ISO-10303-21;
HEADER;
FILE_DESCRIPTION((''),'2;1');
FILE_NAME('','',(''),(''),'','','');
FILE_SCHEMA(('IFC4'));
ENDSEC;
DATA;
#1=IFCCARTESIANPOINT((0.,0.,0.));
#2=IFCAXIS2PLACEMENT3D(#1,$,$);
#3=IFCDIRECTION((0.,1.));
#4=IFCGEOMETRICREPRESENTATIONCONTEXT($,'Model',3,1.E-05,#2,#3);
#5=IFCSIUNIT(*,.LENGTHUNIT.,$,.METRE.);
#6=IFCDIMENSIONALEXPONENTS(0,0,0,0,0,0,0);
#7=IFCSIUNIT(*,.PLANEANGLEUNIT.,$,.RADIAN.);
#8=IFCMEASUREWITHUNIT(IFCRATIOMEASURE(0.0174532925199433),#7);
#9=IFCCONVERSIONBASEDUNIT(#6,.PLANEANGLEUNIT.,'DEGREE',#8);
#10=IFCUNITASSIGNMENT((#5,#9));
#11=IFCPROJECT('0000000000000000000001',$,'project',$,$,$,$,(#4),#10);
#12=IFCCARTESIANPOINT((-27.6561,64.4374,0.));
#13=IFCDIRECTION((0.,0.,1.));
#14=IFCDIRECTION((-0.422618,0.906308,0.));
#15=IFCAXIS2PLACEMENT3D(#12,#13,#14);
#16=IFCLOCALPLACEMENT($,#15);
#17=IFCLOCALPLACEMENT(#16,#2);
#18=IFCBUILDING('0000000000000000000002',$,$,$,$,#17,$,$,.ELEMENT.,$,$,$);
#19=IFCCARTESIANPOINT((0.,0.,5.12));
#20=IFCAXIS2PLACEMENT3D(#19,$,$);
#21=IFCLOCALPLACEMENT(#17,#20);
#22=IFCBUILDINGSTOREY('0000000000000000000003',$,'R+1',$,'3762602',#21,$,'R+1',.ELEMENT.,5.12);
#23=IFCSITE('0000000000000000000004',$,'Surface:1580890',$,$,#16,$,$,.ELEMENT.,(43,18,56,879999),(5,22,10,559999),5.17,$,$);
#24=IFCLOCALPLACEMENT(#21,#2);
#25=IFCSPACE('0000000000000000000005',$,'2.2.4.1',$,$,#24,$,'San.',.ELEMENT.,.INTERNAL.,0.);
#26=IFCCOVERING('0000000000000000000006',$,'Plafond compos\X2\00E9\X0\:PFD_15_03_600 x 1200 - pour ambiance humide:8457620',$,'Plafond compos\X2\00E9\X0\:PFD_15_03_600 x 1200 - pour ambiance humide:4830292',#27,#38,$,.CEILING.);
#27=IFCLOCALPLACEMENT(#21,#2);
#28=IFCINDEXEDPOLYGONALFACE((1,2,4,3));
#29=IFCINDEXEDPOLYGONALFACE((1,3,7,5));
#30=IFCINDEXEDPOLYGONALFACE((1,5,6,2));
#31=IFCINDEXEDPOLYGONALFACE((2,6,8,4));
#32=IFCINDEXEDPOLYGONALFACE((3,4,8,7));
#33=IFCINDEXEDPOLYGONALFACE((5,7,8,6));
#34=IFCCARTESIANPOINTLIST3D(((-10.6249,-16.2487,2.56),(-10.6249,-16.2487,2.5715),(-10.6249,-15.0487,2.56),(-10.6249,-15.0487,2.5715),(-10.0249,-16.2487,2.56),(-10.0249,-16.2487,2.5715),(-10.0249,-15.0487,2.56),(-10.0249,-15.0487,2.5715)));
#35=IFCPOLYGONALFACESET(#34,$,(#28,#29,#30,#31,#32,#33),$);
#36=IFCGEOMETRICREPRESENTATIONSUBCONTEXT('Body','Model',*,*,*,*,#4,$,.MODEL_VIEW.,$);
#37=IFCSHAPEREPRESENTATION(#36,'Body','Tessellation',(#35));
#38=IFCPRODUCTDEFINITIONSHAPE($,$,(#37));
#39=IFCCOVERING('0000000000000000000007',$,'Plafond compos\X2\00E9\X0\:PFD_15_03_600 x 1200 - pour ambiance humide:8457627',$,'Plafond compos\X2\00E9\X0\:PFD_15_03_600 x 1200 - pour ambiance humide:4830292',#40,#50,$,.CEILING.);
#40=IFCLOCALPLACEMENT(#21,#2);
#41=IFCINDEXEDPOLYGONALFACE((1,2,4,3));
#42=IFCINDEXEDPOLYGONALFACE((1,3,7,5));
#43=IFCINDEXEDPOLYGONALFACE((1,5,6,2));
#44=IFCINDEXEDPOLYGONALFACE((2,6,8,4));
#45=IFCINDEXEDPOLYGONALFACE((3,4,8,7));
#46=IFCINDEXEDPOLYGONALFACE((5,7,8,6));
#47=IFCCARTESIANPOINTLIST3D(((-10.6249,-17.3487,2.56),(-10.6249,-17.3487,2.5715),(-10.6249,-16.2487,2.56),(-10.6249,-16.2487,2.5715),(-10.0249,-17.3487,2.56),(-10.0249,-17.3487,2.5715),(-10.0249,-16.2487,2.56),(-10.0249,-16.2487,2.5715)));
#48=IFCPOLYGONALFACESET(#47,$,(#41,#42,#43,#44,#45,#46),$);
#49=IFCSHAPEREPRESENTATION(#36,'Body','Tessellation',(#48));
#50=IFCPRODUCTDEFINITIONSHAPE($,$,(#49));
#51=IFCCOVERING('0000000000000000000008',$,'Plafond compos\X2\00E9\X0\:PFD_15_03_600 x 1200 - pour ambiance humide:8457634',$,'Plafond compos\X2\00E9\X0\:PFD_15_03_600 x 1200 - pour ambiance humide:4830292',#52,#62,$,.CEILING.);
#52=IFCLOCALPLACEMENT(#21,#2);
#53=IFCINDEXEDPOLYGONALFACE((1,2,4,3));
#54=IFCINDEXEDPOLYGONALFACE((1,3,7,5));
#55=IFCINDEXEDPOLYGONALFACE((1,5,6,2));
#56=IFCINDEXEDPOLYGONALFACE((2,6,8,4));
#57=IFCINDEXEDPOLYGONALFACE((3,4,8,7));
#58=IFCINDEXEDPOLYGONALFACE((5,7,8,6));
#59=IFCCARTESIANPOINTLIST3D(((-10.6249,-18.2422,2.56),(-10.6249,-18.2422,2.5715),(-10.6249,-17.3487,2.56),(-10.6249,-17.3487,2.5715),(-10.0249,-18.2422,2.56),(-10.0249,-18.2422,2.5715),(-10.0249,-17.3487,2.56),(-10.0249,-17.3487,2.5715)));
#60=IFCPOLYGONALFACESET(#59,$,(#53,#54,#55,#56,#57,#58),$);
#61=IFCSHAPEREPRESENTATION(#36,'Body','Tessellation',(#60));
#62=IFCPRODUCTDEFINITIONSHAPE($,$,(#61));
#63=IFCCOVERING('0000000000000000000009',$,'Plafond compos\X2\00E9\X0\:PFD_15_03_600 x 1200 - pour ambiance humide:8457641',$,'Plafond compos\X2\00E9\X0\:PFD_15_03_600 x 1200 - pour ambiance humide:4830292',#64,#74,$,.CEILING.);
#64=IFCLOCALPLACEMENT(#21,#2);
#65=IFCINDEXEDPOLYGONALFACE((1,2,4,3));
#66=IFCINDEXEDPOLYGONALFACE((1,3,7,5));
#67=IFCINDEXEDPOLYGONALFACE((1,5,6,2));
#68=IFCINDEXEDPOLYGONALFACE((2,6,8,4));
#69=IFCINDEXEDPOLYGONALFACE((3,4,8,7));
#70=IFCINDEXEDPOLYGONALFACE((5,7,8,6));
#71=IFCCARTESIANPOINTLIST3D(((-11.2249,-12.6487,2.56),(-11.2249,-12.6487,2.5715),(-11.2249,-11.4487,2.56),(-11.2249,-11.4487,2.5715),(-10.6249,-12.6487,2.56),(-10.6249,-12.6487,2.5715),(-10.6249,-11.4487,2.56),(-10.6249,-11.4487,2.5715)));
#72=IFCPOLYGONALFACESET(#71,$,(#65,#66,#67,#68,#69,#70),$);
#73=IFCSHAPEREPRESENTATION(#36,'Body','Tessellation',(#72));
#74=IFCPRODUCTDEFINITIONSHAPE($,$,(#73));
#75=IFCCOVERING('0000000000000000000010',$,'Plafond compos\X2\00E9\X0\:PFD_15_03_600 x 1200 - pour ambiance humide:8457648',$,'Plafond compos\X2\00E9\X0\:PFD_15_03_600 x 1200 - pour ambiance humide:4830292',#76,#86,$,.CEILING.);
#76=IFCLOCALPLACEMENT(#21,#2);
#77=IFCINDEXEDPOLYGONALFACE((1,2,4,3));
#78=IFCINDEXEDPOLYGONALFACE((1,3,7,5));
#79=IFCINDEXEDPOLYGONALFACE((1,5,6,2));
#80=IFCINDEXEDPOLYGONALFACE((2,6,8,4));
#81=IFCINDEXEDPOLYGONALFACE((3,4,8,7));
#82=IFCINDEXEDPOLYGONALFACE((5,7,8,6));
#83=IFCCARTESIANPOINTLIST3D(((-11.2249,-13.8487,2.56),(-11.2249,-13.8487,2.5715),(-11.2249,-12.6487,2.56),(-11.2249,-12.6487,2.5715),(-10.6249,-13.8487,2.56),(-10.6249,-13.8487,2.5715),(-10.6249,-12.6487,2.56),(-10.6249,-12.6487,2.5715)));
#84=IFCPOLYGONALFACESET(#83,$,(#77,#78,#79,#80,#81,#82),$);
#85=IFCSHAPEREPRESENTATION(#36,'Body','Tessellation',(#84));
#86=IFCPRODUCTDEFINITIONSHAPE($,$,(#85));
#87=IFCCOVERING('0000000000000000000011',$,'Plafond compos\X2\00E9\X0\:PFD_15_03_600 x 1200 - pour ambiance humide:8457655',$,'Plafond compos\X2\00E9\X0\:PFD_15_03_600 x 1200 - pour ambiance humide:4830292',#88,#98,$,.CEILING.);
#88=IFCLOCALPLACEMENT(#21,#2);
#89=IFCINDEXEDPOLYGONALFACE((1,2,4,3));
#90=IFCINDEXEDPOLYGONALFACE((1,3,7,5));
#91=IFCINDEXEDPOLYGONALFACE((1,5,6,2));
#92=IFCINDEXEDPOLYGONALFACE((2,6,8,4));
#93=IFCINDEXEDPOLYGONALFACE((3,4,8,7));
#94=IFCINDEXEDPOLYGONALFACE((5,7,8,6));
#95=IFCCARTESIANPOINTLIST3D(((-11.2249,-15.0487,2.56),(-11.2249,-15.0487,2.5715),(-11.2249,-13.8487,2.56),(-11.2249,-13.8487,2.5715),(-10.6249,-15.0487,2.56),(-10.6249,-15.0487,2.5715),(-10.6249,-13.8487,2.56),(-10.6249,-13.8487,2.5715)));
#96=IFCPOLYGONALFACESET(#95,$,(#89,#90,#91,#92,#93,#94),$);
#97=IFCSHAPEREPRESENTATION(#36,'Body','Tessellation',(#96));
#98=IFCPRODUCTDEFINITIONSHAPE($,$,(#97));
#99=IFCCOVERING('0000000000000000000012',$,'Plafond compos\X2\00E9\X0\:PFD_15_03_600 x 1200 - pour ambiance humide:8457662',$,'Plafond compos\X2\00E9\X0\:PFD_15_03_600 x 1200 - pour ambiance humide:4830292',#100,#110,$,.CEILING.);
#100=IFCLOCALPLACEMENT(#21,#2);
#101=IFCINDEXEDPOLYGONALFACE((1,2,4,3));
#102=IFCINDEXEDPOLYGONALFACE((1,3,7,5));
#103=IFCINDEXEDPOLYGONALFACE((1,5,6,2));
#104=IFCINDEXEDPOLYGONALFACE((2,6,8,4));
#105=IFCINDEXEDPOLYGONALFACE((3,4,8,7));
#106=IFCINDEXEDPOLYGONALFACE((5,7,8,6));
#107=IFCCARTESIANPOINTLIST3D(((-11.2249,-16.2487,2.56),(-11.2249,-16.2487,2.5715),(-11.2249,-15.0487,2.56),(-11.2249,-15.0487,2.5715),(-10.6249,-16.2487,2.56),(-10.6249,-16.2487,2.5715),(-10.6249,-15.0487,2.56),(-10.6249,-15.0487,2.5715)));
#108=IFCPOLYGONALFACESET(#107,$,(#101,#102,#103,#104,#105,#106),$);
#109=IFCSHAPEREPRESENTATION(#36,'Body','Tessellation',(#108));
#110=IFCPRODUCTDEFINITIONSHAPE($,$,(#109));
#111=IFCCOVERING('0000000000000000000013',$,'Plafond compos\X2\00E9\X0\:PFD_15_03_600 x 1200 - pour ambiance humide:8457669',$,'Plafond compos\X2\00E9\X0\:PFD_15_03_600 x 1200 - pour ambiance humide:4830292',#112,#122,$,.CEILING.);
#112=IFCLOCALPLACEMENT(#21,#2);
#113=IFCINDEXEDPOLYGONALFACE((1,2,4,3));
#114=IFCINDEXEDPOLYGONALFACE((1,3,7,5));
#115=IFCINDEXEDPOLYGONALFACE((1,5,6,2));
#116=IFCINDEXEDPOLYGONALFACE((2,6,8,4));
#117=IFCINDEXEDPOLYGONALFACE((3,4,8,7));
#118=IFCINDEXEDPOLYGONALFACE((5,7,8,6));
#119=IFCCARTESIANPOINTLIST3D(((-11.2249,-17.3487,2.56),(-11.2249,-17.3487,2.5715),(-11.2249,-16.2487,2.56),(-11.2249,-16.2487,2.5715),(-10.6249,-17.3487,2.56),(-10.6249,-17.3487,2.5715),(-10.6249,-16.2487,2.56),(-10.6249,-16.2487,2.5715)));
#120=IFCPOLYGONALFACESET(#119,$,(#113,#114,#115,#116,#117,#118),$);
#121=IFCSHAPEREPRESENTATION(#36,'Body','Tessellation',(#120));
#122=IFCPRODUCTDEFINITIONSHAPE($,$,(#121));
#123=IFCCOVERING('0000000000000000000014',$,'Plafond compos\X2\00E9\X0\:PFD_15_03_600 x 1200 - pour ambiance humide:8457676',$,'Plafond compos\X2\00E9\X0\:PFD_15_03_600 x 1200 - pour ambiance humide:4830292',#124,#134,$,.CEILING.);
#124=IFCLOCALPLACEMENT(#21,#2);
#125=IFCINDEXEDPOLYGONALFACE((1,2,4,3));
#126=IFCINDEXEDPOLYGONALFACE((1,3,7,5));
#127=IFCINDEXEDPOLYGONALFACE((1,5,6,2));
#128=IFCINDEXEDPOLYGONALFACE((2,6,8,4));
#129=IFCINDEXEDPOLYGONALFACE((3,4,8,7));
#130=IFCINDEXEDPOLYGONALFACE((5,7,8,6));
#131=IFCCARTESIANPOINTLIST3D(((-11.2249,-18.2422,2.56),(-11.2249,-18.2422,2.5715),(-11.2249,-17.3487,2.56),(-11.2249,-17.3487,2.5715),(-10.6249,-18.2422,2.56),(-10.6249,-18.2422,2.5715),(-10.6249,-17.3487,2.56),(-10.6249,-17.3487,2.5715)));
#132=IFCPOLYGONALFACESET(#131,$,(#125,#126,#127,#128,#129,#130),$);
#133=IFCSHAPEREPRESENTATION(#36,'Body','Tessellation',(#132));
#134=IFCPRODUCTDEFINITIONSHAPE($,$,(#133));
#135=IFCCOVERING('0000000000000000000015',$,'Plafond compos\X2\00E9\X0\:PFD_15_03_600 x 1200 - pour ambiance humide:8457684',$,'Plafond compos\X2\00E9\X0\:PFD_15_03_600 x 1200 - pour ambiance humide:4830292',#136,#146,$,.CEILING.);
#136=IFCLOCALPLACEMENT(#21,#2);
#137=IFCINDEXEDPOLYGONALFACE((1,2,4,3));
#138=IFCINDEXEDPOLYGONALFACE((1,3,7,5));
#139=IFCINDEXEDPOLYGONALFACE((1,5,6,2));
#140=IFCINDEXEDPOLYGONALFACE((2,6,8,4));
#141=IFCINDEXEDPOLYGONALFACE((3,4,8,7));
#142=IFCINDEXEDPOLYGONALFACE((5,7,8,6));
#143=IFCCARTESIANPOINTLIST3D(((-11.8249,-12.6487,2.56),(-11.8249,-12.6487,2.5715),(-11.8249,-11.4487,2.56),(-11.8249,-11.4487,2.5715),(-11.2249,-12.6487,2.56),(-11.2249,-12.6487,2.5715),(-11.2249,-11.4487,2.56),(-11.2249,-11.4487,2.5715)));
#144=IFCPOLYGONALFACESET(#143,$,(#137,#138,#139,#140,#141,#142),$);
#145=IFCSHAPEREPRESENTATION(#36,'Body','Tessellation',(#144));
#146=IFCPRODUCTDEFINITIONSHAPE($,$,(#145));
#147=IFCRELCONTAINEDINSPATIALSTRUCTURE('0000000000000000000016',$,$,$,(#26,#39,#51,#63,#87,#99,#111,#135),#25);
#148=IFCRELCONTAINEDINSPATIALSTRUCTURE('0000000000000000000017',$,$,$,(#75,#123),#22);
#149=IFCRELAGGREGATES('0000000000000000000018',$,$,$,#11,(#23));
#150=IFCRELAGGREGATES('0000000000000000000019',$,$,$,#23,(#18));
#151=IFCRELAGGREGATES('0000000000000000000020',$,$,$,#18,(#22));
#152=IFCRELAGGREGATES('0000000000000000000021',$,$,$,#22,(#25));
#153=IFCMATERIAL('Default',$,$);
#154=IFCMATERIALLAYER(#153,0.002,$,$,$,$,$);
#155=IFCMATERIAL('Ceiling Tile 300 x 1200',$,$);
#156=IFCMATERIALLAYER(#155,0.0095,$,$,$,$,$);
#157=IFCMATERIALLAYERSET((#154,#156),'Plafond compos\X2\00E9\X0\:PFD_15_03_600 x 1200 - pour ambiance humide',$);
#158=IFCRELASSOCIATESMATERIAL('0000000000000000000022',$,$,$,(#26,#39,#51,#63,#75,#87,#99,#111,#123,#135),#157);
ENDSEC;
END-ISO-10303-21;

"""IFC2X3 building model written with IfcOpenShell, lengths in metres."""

from ifc_helpers import new_model, entity, si_unit, converted_unit, direction, frame, frame_2d, origin, place, context, subcontext, project, spatial, rectangle, extrude, material, layer, layer_set, layer_usage, element, save


model = new_model("IFC2X3")

# Units and contexts
model_context = context("Model", 3, precision=1e-05, world=origin(), true_north=direction((0.0, 1.0)))
body_context = subcontext(model_context, "Body", "Model", "MODEL_VIEW")
ifc_project = project(units=[si_unit("LENGTHUNIT", "METRE"), converted_unit("PLANEANGLEUNIT", "DEGREE", entity("IfcRatioMeasure", 0.0174532925199433), si_unit("PLANEANGLEUNIT", "RADIAN"), dimensions=[0, 0, 0, 0, 0, 0, 0])], contexts=[model_context])

# Site, building, storey
site_placement = place(None, frame((-27.6561, 64.4374, 0.0), z_axis=(0.0, 0.0, 1.0), x_axis=(-0.422618, 0.906308, 0.0)))
site = spatial("IfcSite", under=ifc_project, at=site_placement, Name="Surface:1580890", CompositionType="ELEMENT", RefLatitude=(43, 18, 56, 879999), RefLongitude=(5, 22, 10, 559999), RefElevation=5.17)
building_placement = place(site_placement, origin())
building = spatial("IfcBuilding", under=site, at=building_placement, CompositionType="ELEMENT")
storey_placement = place(building_placement, frame((0.0, 0.0, 5.12)))
storey = spatial("IfcBuildingStorey", under=building, at=storey_placement, Name="R+1", ObjectType="3762602", LongName="R+1", CompositionType="ELEMENT", Elevation=5.12)

# Shared definitions
ifc_material_1 = material(Name="Default")
ifc_layer_1 = layer(ifc_material_1, 0.002)
ifc_material_2 = material(Name="Ceiling Tile 300 x 1200")
ifc_layer_2 = layer(ifc_material_2, 0.0095)
ifc_layer_set = layer_set([ifc_layer_1, ifc_layer_2], Name="Plafond composé:PFD_15_03_600 x 1200 - pour ambiance humide")

# Shared definitions
space_placement = place(storey_placement, origin())
space = spatial("IfcSpace", under=storey, at=space_placement, Name="2.2.4.1", LongName="San.", CompositionType="ELEMENT", InteriorOrExteriorSpace="INTERNAL", ElevationWithFlooring=0.0)

# Coverings
ifc_layer_usage_1 = layer_usage(ifc_layer_set, "AXIS3", "POSITIVE", 0.0)
covering_1_placement = place(space_placement, origin())
element("IfcCovering", 1, at=covering_1_placement, inside=space, material=ifc_layer_usage_1, Name="Plafond composé:PFD_15_03_600 x 1200 - pour ambiance humide:8457620", ObjectType="Plafond composé:PFD_15_03_600 x 1200 - pour ambiance humide:4830292", PredefinedType="CEILING", context=body_context, shape_type="SweptSolid", body=[
    extrude(rectangle(XDim=0.6, YDim=1.2, at=frame_2d((0.0, 0.0), x_axis=(1.0, 0.0))), frame((-10.3249, -15.6487, 2.56), z_axis=(0.0, 0.0, 1.0), x_axis=(-1.0, 0.0, 0.0)), (0.0, 0.0, 1.0), 0.0115),
])
ifc_layer_usage_2 = layer_usage(ifc_layer_set, "AXIS3", "POSITIVE", 0.0)
covering_2_placement = place(space_placement, origin())
element("IfcCovering", 2, at=covering_2_placement, inside=space, material=ifc_layer_usage_2, Name="Plafond composé:PFD_15_03_600 x 1200 - pour ambiance humide:8457627", ObjectType="Plafond composé:PFD_15_03_600 x 1200 - pour ambiance humide:4830292", PredefinedType="CEILING", context=body_context, shape_type="SweptSolid", body=[
    extrude(rectangle(XDim=0.6, YDim=1.1, at=frame_2d((0.0, 0.0), x_axis=(1.0, 0.0))), frame((-10.3249, -16.7987, 2.56), z_axis=(0.0, 0.0, 1.0), x_axis=(-1.0, 0.0, 0.0)), (0.0, 0.0, 1.0), 0.0115),
])
ifc_layer_usage_3 = layer_usage(ifc_layer_set, "AXIS3", "POSITIVE", 0.0)
covering_3_placement = place(space_placement, origin())
element("IfcCovering", 3, at=covering_3_placement, inside=space, material=ifc_layer_usage_3, Name="Plafond composé:PFD_15_03_600 x 1200 - pour ambiance humide:8457634", ObjectType="Plafond composé:PFD_15_03_600 x 1200 - pour ambiance humide:4830292", PredefinedType="CEILING", context=body_context, shape_type="SweptSolid", body=[
    extrude(rectangle(XDim=0.6, YDim=0.8935, at=frame_2d((0.0, 0.0), x_axis=(1.0, 0.0))), frame((-10.3249, -17.7955, 2.56), z_axis=(0.0, 0.0, 1.0), x_axis=(-1.0, 0.0, 0.0)), (0.0, 0.0, 1.0), 0.0115),
])
ifc_layer_usage_4 = layer_usage(ifc_layer_set, "AXIS3", "POSITIVE", 0.0)
covering_4_placement = place(space_placement, origin())
element("IfcCovering", 4, at=covering_4_placement, inside=space, material=ifc_layer_usage_4, Name="Plafond composé:PFD_15_03_600 x 1200 - pour ambiance humide:8457641", ObjectType="Plafond composé:PFD_15_03_600 x 1200 - pour ambiance humide:4830292", PredefinedType="CEILING", context=body_context, shape_type="SweptSolid", body=[
    extrude(rectangle(XDim=0.6, YDim=1.2, at=frame_2d((0.0, 0.0), x_axis=(1.0, 0.0))), frame((-10.9249, -12.0487, 2.56), z_axis=(0.0, 0.0, 1.0), x_axis=(-1.0, 0.0, 0.0)), (0.0, 0.0, 1.0), 0.0115),
])
ifc_layer_usage_5 = layer_usage(ifc_layer_set, "AXIS3", "POSITIVE", 0.0)
covering_5_placement = place(storey_placement, origin())
element("IfcCovering", 5, at=covering_5_placement, inside=storey, material=ifc_layer_usage_5, Name="Plafond composé:PFD_15_03_600 x 1200 - pour ambiance humide:8457648", ObjectType="Plafond composé:PFD_15_03_600 x 1200 - pour ambiance humide:4830292", PredefinedType="CEILING", context=body_context, shape_type="SweptSolid", body=[
    extrude(rectangle(XDim=0.6, YDim=1.2, at=frame_2d((0.0, 0.0), x_axis=(1.0, 0.0))), frame((-10.9249, -13.2487, 2.56), z_axis=(0.0, 0.0, 1.0), x_axis=(-1.0, 0.0, 0.0)), (0.0, 0.0, 1.0), 0.0115),
])
ifc_layer_usage_6 = layer_usage(ifc_layer_set, "AXIS3", "POSITIVE", 0.0)
covering_6_placement = place(space_placement, origin())
element("IfcCovering", 6, at=covering_6_placement, inside=space, material=ifc_layer_usage_6, Name="Plafond composé:PFD_15_03_600 x 1200 - pour ambiance humide:8457655", ObjectType="Plafond composé:PFD_15_03_600 x 1200 - pour ambiance humide:4830292", PredefinedType="CEILING", context=body_context, shape_type="SweptSolid", body=[
    extrude(rectangle(XDim=0.6, YDim=1.2, at=frame_2d((0.0, 0.0), x_axis=(1.0, 0.0))), frame((-10.9249, -14.4487, 2.56), z_axis=(0.0, 0.0, 1.0), x_axis=(-1.0, 0.0, 0.0)), (0.0, 0.0, 1.0), 0.0115),
])
ifc_layer_usage_7 = layer_usage(ifc_layer_set, "AXIS3", "POSITIVE", 0.0)
covering_7_placement = place(space_placement, origin())
element("IfcCovering", 7, at=covering_7_placement, inside=space, material=ifc_layer_usage_7, Name="Plafond composé:PFD_15_03_600 x 1200 - pour ambiance humide:8457662", ObjectType="Plafond composé:PFD_15_03_600 x 1200 - pour ambiance humide:4830292", PredefinedType="CEILING", context=body_context, shape_type="SweptSolid", body=[
    extrude(rectangle(XDim=0.6, YDim=1.2, at=frame_2d((0.0, 0.0), x_axis=(1.0, 0.0))), frame((-10.9249, -15.6487, 2.56), z_axis=(0.0, 0.0, 1.0), x_axis=(-1.0, 0.0, 0.0)), (0.0, 0.0, 1.0), 0.0115),
])
ifc_layer_usage_8 = layer_usage(ifc_layer_set, "AXIS3", "POSITIVE", 0.0)
covering_8_placement = place(space_placement, origin())
element("IfcCovering", 8, at=covering_8_placement, inside=space, material=ifc_layer_usage_8, Name="Plafond composé:PFD_15_03_600 x 1200 - pour ambiance humide:8457669", ObjectType="Plafond composé:PFD_15_03_600 x 1200 - pour ambiance humide:4830292", PredefinedType="CEILING", context=body_context, shape_type="SweptSolid", body=[
    extrude(rectangle(XDim=0.6, YDim=1.1, at=frame_2d((0.0, 0.0), x_axis=(1.0, 0.0))), frame((-10.9249, -16.7987, 2.56), z_axis=(0.0, 0.0, 1.0), x_axis=(-1.0, 0.0, 0.0)), (0.0, 0.0, 1.0), 0.0115),
])
ifc_layer_usage_9 = layer_usage(ifc_layer_set, "AXIS3", "POSITIVE", 0.0)
covering_9_placement = place(storey_placement, origin())
element("IfcCovering", 9, at=covering_9_placement, inside=storey, material=ifc_layer_usage_9, Name="Plafond composé:PFD_15_03_600 x 1200 - pour ambiance humide:8457676", ObjectType="Plafond composé:PFD_15_03_600 x 1200 - pour ambiance humide:4830292", PredefinedType="CEILING", context=body_context, shape_type="SweptSolid", body=[
    extrude(rectangle(XDim=0.6, YDim=0.8935, at=frame_2d((0.0, 0.0), x_axis=(1.0, 0.0))), frame((-10.9249, -17.7955, 2.56), z_axis=(0.0, 0.0, 1.0), x_axis=(-1.0, 0.0, 0.0)), (0.0, 0.0, 1.0), 0.0115),
])
ifc_layer_usage_10 = layer_usage(ifc_layer_set, "AXIS3", "POSITIVE", 0.0)
covering_10_placement = place(space_placement, origin())
element("IfcCovering", 10, at=covering_10_placement, inside=space, material=ifc_layer_usage_10, Name="Plafond composé:PFD_15_03_600 x 1200 - pour ambiance humide:8457684", ObjectType="Plafond composé:PFD_15_03_600 x 1200 - pour ambiance humide:4830292", PredefinedType="CEILING", context=body_context, shape_type="SweptSolid", body=[
    extrude(rectangle(XDim=0.6, YDim=1.2, at=frame_2d((0.0, 0.0), x_axis=(1.0, 0.0))), frame((-11.5249, -12.0487, 2.56), z_axis=(0.0, 0.0, 1.0), x_axis=(-1.0, 0.0, 0.0)), (0.0, 0.0, 1.0), 0.0115),
])

save(model, "model.ifc")
